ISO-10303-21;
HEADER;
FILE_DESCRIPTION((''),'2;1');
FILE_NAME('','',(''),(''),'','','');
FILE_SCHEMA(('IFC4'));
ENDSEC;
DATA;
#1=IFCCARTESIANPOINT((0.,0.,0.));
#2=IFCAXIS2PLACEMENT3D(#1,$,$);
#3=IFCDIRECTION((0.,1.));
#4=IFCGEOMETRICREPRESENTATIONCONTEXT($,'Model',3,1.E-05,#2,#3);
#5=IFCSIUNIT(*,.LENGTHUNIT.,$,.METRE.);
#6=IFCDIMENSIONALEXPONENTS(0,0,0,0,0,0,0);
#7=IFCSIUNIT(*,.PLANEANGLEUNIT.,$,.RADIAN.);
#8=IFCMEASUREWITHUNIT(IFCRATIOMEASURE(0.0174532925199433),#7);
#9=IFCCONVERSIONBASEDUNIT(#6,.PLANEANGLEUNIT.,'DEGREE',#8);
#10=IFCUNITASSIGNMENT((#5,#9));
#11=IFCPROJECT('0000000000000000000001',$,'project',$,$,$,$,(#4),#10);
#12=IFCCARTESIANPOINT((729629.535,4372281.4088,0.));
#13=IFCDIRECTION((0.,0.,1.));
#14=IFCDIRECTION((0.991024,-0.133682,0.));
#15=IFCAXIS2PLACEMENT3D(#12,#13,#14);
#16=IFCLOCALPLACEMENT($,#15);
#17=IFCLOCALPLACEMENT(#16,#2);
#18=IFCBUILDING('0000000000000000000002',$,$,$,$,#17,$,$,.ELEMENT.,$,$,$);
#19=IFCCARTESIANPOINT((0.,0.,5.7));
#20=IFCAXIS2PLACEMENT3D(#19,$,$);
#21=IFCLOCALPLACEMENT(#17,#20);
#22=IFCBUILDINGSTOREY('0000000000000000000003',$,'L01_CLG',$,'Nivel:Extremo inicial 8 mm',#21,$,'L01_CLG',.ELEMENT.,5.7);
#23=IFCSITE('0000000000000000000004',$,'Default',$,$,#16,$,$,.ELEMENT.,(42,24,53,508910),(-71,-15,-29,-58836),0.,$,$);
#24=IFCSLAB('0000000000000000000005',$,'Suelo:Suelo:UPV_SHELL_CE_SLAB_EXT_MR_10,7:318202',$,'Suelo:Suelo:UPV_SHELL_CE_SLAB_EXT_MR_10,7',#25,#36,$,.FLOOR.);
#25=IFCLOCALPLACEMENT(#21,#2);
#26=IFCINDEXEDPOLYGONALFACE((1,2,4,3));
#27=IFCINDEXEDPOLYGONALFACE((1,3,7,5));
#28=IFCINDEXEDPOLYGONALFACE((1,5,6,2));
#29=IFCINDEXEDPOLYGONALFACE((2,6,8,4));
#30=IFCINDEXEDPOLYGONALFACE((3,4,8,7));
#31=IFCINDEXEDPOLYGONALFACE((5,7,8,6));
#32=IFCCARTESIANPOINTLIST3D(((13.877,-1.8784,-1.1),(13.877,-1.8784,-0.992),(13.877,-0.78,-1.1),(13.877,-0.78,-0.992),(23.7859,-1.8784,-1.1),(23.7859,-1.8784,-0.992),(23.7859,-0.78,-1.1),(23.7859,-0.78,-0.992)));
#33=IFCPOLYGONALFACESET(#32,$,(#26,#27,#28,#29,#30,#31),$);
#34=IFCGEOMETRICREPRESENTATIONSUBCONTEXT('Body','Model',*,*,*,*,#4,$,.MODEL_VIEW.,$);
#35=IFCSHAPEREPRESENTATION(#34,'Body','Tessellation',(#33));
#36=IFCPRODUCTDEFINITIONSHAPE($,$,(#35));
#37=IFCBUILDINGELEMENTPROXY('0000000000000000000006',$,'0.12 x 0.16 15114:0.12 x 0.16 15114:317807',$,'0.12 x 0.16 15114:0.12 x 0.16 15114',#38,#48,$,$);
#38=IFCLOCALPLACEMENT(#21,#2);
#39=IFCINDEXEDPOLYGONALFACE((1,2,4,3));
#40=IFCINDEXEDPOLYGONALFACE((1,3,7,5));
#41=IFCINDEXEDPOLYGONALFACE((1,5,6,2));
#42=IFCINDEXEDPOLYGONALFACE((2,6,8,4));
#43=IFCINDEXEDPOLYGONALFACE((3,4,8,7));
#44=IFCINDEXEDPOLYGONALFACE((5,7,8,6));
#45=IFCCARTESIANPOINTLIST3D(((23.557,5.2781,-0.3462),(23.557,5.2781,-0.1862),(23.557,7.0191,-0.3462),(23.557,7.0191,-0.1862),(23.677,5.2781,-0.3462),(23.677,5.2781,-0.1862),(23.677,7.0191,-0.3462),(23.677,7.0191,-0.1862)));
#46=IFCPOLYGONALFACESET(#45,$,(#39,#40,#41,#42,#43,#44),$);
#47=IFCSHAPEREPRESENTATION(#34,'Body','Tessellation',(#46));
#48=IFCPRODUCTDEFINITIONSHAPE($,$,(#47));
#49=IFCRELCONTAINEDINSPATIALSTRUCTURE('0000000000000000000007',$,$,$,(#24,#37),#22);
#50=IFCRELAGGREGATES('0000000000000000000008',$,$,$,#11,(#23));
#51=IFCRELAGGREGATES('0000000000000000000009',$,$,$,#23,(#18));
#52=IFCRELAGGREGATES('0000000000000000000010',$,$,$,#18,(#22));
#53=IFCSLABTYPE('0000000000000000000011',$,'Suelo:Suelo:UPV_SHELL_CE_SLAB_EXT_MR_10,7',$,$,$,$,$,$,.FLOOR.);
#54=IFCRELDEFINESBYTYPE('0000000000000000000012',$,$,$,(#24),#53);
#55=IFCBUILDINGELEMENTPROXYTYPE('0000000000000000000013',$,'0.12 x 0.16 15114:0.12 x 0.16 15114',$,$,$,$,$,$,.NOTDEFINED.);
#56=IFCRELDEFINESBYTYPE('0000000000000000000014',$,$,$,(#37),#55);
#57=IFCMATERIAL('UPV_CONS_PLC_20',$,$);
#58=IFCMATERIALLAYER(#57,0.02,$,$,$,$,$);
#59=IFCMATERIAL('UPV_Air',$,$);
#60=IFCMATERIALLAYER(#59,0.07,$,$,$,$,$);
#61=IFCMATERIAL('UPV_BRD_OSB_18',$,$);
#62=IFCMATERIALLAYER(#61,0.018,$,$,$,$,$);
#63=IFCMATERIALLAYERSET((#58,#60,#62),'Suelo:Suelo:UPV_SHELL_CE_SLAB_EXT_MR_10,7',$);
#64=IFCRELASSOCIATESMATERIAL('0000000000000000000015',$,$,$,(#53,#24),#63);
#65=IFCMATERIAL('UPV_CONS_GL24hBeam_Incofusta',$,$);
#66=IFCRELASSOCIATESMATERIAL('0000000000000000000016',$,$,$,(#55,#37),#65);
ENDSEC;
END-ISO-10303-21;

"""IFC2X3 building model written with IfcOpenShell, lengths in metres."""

from ifc_helpers import new_model, entity, si_unit, converted_unit, direction, frame, frame_2d, origin, origin_2d_with_axis, place, context, subcontext, project, spatial, rectangle, extrude, source, transform, mapped, material, layer, layer_set, layer_usage, type_object, type_shapes, element, save


model = new_model("IFC2X3")

# Units and contexts
model_context = context("Model", 3, precision=1e-05, world=origin(), true_north=direction((0.0, 1.0)))
body_context = subcontext(model_context, "Body", "Model", "MODEL_VIEW")
ifc_project = project(units=[si_unit("LENGTHUNIT", "METRE"), converted_unit("PLANEANGLEUNIT", "DEGREE", entity("IfcRatioMeasure", 0.0174532925199433), si_unit("PLANEANGLEUNIT", "RADIAN"), dimensions=[0, 0, 0, 0, 0, 0, 0])], contexts=[model_context])

# Site, building, storey
site_placement = place(None, frame((729629.535, 4372281.4088, 0.0), z_axis=(0.0, 0.0, 1.0), x_axis=(0.991024, -0.133682, 0.0)))
site = spatial("IfcSite", under=ifc_project, at=site_placement, Name="Default", CompositionType="ELEMENT", RefLatitude=(42, 24, 53, 508910), RefLongitude=(-71, -15, -29, -58836), RefElevation=0.0)
building_placement = place(site_placement, origin())
building = spatial("IfcBuilding", under=site, at=building_placement, CompositionType="ELEMENT")
storey_placement = place(building_placement, frame((0.0, 0.0, 5.7)))
storey = spatial("IfcBuildingStorey", under=building, at=storey_placement, Name="L01_CLG", ObjectType="Nivel:Extremo inicial 8 mm", LongName="L01_CLG", CompositionType="ELEMENT", Elevation=5.7)

# Slab
ifc_material_1 = material(Name="UPV_CONS_PLC_20")
ifc_layer_1 = layer(ifc_material_1, 0.02)
ifc_material_2 = material(Name="UPV_Air")
ifc_layer_2 = layer(ifc_material_2, 0.07)
ifc_material_3 = material(Name="UPV_BRD_OSB_18")
ifc_layer_3 = layer(ifc_material_3, 0.018)
ifc_layer_set = layer_set([ifc_layer_1, ifc_layer_2, ifc_layer_3], Name="Suelo:Suelo:UPV_SHELL_CE_SLAB_EXT_MR_10,7")
ifc_layer_usage = layer_usage(ifc_layer_set, "AXIS3", "POSITIVE", 0.0)
slab_type = type_object("IfcSlabType", Name="Suelo:Suelo:UPV_SHELL_CE_SLAB_EXT_MR_10,7", PredefinedType="FLOOR", material=ifc_layer_set)
slab_placement = place(storey_placement, origin())
element("IfcSlab", 1, at=slab_placement, inside=storey, type_object=slab_type, material=ifc_layer_usage, Name="Suelo:Suelo:UPV_SHELL_CE_SLAB_EXT_MR_10,7:318202", ObjectType="Suelo:Suelo:UPV_SHELL_CE_SLAB_EXT_MR_10,7", PredefinedType="FLOOR", context=body_context, shape_type="SweptSolid", body=[
    extrude(rectangle(XDim=1.0984, YDim=9.909, at=frame_2d((0.0, 0.0), x_axis=(1.0, 0.0))), frame((18.8314, -1.3292, -0.992), z_axis=(0.0, 0.0, -1.0), x_axis=(0.0, 1.0, 0.0)), (0.0, 0.0, 1.0), 0.108),
])

# Building element proxy
ifc_material_4 = material(Name="UPV_CONS_GL24hBeam_Incofusta")
building_element_proxy_type = type_object("IfcBuildingElementProxyType", Name="0.12 x 0.16 15114:0.12 x 0.16 15114", PredefinedType="NOTDEFINED", material=ifc_material_4)
shared_shape_1 = source(origin(), body_context, "Body", "SweptSolid", [
    extrude(rectangle(XDim=0.12, YDim=1.741, at=origin_2d_with_axis()), frame((-0.005, 0.0, -0.08), z_axis=(0.0, 0.0, 1.0), x_axis=(0.0, 1.0, 0.0)), (0.0, 0.0, 1.0), 0.16),
])
type_shapes(building_element_proxy_type, [shared_shape_1])
proxy_placement = place(storey_placement, frame((23.617, 6.1436, -0.2662), z_axis=(0.0, 0.0, 1.0), x_axis=(0.0, -1.0, 0.0)))
element("IfcBuildingElementProxy", 2, at=proxy_placement, inside=storey, type_object=building_element_proxy_type, material=ifc_material_4, Name="0.12 x 0.16 15114:0.12 x 0.16 15114:317807", ObjectType="0.12 x 0.16 15114:0.12 x 0.16 15114", context=body_context, shape_type="MappedRepresentation", body=[
    mapped(shared_shape_1, transform((0.0, 0.0, 0.0), scale=1.0)),
])

save(model, "model.ifc")
